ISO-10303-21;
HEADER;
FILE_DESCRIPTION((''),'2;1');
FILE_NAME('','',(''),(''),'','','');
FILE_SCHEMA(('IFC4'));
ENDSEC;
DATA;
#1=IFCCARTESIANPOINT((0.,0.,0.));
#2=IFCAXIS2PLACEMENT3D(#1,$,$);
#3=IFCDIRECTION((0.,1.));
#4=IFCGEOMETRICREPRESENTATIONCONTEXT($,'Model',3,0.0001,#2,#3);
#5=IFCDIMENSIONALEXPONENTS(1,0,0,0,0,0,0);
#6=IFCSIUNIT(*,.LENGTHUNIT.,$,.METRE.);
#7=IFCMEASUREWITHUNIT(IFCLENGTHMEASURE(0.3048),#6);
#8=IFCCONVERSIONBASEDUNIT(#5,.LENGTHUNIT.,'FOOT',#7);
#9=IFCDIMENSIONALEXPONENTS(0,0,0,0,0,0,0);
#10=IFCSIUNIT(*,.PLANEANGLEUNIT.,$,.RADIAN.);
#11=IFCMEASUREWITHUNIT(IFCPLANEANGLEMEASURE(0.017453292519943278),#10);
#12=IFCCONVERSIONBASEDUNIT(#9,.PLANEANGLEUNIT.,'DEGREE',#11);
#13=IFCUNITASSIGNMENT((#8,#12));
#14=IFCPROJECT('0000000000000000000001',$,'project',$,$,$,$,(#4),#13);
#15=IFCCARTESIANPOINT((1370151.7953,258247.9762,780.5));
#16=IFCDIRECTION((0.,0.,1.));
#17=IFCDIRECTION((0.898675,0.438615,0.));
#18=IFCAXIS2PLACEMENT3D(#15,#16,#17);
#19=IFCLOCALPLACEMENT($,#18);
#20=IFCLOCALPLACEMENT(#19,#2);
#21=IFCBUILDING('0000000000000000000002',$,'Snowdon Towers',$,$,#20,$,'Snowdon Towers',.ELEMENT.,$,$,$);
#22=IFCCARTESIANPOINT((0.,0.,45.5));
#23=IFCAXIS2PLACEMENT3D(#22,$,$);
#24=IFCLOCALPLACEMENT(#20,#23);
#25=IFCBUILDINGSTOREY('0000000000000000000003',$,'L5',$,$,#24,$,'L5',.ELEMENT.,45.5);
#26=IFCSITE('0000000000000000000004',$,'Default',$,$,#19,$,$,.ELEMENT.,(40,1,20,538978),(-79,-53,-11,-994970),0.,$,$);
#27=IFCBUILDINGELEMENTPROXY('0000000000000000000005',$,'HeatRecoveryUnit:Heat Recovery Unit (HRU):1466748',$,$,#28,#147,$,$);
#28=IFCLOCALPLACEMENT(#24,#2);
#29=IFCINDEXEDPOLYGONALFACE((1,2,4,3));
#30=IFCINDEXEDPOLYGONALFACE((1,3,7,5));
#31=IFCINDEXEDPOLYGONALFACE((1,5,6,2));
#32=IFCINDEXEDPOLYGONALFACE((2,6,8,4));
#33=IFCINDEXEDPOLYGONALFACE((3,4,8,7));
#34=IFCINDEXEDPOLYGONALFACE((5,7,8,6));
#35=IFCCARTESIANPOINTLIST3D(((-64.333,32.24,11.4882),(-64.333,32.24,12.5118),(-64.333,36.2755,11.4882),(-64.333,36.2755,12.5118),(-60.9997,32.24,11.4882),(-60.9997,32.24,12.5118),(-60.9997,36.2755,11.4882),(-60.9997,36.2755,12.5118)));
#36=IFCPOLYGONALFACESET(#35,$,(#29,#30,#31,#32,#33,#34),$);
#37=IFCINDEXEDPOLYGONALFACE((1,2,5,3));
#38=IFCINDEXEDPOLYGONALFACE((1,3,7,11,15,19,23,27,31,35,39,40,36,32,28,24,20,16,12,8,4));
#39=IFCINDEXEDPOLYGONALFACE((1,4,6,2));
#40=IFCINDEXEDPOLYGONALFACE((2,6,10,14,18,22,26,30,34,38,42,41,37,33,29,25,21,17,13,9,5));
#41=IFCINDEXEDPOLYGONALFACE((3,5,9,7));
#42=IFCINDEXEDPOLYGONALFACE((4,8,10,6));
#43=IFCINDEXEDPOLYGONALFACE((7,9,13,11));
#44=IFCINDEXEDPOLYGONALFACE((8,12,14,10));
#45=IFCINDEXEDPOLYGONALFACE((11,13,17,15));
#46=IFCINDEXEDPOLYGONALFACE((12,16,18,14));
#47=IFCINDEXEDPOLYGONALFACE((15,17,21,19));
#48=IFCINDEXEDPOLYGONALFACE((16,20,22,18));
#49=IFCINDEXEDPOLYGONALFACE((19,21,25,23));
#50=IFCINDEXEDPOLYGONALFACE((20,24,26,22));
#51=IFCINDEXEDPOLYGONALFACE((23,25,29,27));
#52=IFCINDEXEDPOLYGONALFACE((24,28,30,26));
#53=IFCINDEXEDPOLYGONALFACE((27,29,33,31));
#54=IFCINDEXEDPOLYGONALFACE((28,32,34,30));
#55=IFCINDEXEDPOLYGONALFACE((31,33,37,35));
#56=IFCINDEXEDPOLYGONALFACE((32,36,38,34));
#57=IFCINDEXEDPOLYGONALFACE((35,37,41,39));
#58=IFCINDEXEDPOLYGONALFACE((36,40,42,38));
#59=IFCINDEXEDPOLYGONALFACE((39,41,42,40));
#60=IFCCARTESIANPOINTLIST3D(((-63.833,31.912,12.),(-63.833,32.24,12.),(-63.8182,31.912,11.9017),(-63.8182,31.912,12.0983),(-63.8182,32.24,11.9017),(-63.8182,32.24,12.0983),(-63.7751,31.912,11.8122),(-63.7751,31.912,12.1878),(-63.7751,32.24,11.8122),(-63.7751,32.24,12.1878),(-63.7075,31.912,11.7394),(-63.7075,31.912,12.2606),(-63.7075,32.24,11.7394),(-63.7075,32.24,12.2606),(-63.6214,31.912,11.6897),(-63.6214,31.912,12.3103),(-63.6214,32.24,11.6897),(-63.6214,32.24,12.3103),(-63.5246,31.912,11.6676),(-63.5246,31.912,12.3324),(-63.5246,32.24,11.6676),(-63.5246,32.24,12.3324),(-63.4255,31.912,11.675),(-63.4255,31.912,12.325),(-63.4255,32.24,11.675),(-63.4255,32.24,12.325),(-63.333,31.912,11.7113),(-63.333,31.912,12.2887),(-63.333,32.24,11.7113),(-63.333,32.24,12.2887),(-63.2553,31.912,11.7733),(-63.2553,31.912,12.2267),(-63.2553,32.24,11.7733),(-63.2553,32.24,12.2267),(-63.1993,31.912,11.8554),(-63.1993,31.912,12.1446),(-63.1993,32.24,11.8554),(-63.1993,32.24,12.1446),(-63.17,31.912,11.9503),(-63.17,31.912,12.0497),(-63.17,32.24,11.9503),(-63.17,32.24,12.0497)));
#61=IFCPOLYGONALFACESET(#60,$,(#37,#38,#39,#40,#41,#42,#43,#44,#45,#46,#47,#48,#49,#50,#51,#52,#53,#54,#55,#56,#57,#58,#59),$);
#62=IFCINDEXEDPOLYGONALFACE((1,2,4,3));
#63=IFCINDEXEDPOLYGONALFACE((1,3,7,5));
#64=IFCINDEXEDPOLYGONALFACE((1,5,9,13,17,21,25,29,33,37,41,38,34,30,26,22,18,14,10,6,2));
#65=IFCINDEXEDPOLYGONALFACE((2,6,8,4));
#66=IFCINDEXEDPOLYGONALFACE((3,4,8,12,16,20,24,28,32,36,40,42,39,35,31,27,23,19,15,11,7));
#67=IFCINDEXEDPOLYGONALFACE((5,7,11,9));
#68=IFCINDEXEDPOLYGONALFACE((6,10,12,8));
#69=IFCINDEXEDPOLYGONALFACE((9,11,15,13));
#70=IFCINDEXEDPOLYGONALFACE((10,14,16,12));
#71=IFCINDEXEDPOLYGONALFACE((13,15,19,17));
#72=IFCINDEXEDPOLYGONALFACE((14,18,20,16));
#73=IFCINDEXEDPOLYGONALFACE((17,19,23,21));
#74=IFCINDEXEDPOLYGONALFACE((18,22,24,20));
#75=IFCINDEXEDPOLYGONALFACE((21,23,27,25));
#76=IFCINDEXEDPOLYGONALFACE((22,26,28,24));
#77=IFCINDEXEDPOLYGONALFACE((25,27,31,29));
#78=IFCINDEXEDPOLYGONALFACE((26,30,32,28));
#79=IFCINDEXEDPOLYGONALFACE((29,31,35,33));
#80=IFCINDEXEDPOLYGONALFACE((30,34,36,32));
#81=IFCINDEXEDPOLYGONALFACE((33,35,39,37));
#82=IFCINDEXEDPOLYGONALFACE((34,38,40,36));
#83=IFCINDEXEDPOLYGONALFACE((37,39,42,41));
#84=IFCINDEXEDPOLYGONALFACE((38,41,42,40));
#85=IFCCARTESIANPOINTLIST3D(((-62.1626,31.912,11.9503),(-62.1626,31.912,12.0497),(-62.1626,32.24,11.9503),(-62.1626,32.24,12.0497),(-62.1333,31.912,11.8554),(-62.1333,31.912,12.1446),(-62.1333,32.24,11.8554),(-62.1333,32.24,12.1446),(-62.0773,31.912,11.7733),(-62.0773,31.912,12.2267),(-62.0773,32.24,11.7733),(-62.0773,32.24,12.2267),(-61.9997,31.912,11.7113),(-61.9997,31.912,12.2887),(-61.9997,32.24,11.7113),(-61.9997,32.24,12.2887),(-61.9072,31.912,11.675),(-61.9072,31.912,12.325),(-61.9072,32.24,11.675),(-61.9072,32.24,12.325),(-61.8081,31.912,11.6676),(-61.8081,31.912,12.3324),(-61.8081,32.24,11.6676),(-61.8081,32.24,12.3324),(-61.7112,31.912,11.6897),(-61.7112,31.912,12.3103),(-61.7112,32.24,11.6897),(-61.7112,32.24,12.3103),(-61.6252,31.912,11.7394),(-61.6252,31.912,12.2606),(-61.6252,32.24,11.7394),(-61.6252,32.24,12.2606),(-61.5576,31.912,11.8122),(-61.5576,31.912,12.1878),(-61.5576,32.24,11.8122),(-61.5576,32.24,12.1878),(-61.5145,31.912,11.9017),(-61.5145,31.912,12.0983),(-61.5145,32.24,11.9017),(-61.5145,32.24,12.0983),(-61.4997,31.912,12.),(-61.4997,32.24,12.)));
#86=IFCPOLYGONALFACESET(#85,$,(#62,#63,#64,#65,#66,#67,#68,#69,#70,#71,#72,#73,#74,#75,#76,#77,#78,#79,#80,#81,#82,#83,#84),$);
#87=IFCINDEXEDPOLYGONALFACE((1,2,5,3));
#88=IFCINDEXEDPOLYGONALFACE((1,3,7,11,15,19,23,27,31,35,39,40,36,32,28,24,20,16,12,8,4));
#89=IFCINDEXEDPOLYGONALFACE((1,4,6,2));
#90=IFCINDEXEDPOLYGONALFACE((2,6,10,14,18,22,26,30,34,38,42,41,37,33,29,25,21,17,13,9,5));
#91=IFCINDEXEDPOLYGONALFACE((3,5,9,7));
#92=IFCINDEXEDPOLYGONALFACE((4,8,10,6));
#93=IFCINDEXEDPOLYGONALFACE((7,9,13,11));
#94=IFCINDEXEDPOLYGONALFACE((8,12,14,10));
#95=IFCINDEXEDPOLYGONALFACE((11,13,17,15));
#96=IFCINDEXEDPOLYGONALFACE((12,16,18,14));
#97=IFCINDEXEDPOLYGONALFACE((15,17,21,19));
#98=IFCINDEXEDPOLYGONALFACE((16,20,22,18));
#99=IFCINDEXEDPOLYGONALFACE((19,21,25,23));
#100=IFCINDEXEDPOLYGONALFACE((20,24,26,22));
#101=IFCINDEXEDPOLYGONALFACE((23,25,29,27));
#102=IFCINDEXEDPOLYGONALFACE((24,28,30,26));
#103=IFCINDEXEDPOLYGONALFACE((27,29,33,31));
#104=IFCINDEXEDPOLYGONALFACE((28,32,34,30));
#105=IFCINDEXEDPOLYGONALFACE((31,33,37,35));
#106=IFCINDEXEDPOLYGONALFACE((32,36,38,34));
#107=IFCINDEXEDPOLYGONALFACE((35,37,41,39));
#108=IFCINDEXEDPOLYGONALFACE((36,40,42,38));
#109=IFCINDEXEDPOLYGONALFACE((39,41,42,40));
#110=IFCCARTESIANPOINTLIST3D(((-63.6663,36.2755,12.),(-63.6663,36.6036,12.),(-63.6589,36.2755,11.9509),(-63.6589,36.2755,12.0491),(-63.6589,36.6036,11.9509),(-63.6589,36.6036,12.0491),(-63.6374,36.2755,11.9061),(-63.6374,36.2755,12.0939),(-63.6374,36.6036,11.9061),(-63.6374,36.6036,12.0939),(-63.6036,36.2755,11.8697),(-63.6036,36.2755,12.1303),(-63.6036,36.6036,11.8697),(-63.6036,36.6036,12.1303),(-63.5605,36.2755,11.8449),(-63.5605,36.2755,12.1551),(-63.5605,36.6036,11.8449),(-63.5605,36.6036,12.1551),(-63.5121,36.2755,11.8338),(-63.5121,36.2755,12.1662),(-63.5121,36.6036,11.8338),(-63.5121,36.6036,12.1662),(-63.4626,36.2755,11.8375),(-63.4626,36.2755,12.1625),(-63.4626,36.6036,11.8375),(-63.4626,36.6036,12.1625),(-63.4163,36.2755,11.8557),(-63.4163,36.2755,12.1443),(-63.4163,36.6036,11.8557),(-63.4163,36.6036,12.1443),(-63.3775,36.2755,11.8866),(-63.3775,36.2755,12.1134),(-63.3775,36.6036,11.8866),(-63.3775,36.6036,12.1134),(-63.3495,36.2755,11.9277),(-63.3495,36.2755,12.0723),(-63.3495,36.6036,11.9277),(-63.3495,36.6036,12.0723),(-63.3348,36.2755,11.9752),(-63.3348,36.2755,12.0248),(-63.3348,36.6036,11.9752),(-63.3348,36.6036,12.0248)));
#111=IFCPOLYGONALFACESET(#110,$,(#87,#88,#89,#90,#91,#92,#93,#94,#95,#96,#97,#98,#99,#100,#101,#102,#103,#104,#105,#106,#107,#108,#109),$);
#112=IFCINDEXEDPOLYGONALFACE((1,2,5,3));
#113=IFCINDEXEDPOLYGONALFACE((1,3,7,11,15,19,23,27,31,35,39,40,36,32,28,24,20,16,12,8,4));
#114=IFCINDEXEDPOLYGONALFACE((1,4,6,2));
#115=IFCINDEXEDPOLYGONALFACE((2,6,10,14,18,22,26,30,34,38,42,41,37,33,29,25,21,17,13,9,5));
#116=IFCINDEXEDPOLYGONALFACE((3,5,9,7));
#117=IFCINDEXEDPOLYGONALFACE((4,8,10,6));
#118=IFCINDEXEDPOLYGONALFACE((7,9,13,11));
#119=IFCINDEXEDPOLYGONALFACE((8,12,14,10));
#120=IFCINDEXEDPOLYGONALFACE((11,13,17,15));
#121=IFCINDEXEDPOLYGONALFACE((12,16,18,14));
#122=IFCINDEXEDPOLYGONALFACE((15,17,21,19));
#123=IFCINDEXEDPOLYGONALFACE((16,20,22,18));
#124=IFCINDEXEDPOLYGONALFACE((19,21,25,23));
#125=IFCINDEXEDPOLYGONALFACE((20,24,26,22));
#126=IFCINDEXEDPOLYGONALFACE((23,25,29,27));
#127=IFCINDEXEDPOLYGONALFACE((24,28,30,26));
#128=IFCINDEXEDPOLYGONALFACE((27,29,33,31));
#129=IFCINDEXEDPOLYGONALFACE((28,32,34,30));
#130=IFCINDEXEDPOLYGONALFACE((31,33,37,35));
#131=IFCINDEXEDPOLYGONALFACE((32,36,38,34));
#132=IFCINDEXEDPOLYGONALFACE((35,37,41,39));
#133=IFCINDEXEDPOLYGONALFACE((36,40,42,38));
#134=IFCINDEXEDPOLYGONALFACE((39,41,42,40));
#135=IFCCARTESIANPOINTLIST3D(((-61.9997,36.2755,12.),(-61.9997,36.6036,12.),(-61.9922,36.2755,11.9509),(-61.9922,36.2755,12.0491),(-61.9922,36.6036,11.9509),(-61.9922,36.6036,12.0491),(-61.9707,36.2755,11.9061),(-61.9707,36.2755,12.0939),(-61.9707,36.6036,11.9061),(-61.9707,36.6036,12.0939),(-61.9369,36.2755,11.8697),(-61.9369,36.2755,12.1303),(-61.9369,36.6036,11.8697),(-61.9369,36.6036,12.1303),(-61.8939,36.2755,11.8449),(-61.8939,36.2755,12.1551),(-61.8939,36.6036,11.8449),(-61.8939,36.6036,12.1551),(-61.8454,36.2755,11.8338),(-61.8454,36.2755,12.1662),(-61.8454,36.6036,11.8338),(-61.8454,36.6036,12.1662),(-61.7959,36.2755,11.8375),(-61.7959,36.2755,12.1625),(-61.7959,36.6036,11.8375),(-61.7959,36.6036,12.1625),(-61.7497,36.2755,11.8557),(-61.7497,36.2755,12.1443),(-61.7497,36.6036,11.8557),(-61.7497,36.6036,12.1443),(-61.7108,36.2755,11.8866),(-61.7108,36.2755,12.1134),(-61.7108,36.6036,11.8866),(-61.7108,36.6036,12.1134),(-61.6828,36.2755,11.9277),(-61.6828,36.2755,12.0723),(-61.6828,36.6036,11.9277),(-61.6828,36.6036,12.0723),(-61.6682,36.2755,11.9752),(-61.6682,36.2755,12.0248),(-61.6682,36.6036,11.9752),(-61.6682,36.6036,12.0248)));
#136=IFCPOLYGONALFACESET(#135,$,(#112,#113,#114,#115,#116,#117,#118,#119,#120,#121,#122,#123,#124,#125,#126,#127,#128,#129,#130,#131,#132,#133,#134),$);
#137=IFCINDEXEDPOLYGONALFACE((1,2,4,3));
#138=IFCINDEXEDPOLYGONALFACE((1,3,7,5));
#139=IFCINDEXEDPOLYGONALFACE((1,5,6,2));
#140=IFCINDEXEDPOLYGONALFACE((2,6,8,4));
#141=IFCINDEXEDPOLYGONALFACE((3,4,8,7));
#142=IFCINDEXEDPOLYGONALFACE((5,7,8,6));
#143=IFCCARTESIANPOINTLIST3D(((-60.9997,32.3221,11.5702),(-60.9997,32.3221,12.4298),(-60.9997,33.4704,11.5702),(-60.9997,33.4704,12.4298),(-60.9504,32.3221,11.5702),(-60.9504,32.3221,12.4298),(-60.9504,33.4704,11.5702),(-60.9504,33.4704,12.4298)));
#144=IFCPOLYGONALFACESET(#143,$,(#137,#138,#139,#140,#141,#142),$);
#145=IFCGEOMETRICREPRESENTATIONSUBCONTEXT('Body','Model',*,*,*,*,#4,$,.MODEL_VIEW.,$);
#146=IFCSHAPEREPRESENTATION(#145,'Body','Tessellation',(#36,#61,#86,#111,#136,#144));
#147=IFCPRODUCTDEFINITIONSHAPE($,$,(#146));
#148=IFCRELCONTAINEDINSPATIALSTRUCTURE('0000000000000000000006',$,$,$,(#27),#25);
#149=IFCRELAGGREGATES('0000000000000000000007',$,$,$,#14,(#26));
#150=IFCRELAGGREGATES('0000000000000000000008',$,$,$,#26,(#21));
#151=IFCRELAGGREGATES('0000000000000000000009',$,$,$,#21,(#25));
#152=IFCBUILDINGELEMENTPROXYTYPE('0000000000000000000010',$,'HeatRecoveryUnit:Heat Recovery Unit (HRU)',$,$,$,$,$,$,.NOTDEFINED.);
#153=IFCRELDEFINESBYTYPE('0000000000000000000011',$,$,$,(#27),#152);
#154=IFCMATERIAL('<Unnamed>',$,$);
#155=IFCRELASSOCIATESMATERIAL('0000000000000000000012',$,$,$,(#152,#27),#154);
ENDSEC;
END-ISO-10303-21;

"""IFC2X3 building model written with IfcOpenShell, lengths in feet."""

from ifc_helpers import new_model, entity, si_unit, converted_unit, direction, frame, frame_2d, origin, origin_2d_with_axis, place, context, subcontext, project, spatial, rectangle, circle, extrude, source, transform, mapped, material, type_object, type_shapes, element, save


model = new_model("IFC2X3")

# Units and contexts
model_context = context("Model", 3, precision=0.0001, world=origin(), true_north=direction((0.0, 1.0)))
body_context = subcontext(model_context, "Body", "Model", "MODEL_VIEW")
ifc_project = project(units=[converted_unit("LENGTHUNIT", "FOOT", entity("IfcLengthMeasure", 0.3048), si_unit("LENGTHUNIT", "METRE"), dimensions=[1, 0, 0, 0, 0, 0, 0]), converted_unit("PLANEANGLEUNIT", "DEGREE", entity("IfcPlaneAngleMeasure", 0.017453292519943278), si_unit("PLANEANGLEUNIT", "RADIAN"), dimensions=[0, 0, 0, 0, 0, 0, 0])], contexts=[model_context])

# Site, building, storey
site_placement = place(None, frame((1370151.7953, 258247.9762, 780.5), z_axis=(0.0, 0.0, 1.0), x_axis=(0.898675, 0.438615, 0.0)))
site = spatial("IfcSite", under=ifc_project, at=site_placement, Name="Default", CompositionType="ELEMENT", RefLatitude=(40, 1, 20, 538978), RefLongitude=(-79, -53, -11, -994970), RefElevation=0.0)
building_placement = place(site_placement, origin())
building = spatial("IfcBuilding", under=site, at=building_placement, Name="Snowdon Towers", LongName="Snowdon Towers", CompositionType="ELEMENT")
storey_placement = place(building_placement, frame((0.0, 0.0, 45.5)))
storey = spatial("IfcBuildingStorey", under=building, at=storey_placement, Name="L5", LongName="L5", CompositionType="ELEMENT", Elevation=45.5)

# Shared definitions
ifc_material = material(Name="<Unnamed>")

# Building element proxy
building_element_proxy_type = type_object("IfcBuildingElementProxyType", Name="HeatRecoveryUnit:Heat Recovery Unit (HRU)", PredefinedType="NOTDEFINED", material=ifc_material)
shared_shape_1 = source(origin(), body_context, "Body", "SweptSolid", [
    extrude(rectangle(XDim=3.3333, YDim=4.0354, at=origin_2d_with_axis()), frame((0.0, 0.0, 0.0), z_axis=(0.0, 0.0, 1.0), x_axis=(-1.0, 0.0, 0.0)), (0.0, 0.0, 1.0), 1.0236),
    extrude(circle(Radius=0.3333, at=frame_2d((0.0, 0.0), x_axis=(1.0, 0.0))), frame((-0.8333, -2.3458, 0.5118), z_axis=(0.0, 1.0, 0.0), x_axis=(-1.0, 0.0, 0.0)), (0.0, 0.0, 1.0), 0.3281),
    extrude(circle(Radius=0.3333, at=frame_2d((0.0, 0.0), x_axis=(1.0, 0.0))), frame((0.8333, -2.3458, 0.5118), z_axis=(0.0, 1.0, 0.0), x_axis=(1.0, 0.0, 0.0)), (0.0, 0.0, 1.0), 0.3281),
    extrude(circle(Radius=0.1667, at=frame_2d((0.0, 0.0), x_axis=(1.0, 0.0))), frame((-0.8333, 2.0177, 0.5118), z_axis=(0.0, 1.0, 0.0), x_axis=(-1.0, 0.0, 0.0)), (0.0, 0.0, 1.0), 0.3281),
    extrude(circle(Radius=0.1667, at=frame_2d((0.0, 0.0), x_axis=(1.0, 0.0))), frame((0.8333, 2.0177, 0.5118), z_axis=(0.0, 1.0, 0.0), x_axis=(-1.0, 0.0, 0.0)), (0.0, 0.0, 1.0), 0.3281),
    extrude(rectangle(XDim=0.0492, YDim=1.1483, at=origin_2d_with_axis()), frame((1.6913, -1.3615, 0.082), z_axis=(0.0, 0.0, 1.0), x_axis=(-1.0, 0.0, 0.0)), (0.0, 0.0, 1.0), 0.8596),
])
type_shapes(building_element_proxy_type, [shared_shape_1])
for number, where, name in (
    (1, (-62.6663, 34.2578, 11.4882), "HeatRecoveryUnit:Heat Recovery Unit (HRU):1466748"),
):
    element("IfcBuildingElementProxy", number, at=place(storey_placement, frame(where)), inside=storey, type_object=building_element_proxy_type, material=ifc_material, Name=name, context=body_context, shape_type="MappedRepresentation", body=[
        mapped(shared_shape_1, transform((0.0, 0.0, 0.0), scale=1.0)),
    ])

save(model, "model.ifc")
